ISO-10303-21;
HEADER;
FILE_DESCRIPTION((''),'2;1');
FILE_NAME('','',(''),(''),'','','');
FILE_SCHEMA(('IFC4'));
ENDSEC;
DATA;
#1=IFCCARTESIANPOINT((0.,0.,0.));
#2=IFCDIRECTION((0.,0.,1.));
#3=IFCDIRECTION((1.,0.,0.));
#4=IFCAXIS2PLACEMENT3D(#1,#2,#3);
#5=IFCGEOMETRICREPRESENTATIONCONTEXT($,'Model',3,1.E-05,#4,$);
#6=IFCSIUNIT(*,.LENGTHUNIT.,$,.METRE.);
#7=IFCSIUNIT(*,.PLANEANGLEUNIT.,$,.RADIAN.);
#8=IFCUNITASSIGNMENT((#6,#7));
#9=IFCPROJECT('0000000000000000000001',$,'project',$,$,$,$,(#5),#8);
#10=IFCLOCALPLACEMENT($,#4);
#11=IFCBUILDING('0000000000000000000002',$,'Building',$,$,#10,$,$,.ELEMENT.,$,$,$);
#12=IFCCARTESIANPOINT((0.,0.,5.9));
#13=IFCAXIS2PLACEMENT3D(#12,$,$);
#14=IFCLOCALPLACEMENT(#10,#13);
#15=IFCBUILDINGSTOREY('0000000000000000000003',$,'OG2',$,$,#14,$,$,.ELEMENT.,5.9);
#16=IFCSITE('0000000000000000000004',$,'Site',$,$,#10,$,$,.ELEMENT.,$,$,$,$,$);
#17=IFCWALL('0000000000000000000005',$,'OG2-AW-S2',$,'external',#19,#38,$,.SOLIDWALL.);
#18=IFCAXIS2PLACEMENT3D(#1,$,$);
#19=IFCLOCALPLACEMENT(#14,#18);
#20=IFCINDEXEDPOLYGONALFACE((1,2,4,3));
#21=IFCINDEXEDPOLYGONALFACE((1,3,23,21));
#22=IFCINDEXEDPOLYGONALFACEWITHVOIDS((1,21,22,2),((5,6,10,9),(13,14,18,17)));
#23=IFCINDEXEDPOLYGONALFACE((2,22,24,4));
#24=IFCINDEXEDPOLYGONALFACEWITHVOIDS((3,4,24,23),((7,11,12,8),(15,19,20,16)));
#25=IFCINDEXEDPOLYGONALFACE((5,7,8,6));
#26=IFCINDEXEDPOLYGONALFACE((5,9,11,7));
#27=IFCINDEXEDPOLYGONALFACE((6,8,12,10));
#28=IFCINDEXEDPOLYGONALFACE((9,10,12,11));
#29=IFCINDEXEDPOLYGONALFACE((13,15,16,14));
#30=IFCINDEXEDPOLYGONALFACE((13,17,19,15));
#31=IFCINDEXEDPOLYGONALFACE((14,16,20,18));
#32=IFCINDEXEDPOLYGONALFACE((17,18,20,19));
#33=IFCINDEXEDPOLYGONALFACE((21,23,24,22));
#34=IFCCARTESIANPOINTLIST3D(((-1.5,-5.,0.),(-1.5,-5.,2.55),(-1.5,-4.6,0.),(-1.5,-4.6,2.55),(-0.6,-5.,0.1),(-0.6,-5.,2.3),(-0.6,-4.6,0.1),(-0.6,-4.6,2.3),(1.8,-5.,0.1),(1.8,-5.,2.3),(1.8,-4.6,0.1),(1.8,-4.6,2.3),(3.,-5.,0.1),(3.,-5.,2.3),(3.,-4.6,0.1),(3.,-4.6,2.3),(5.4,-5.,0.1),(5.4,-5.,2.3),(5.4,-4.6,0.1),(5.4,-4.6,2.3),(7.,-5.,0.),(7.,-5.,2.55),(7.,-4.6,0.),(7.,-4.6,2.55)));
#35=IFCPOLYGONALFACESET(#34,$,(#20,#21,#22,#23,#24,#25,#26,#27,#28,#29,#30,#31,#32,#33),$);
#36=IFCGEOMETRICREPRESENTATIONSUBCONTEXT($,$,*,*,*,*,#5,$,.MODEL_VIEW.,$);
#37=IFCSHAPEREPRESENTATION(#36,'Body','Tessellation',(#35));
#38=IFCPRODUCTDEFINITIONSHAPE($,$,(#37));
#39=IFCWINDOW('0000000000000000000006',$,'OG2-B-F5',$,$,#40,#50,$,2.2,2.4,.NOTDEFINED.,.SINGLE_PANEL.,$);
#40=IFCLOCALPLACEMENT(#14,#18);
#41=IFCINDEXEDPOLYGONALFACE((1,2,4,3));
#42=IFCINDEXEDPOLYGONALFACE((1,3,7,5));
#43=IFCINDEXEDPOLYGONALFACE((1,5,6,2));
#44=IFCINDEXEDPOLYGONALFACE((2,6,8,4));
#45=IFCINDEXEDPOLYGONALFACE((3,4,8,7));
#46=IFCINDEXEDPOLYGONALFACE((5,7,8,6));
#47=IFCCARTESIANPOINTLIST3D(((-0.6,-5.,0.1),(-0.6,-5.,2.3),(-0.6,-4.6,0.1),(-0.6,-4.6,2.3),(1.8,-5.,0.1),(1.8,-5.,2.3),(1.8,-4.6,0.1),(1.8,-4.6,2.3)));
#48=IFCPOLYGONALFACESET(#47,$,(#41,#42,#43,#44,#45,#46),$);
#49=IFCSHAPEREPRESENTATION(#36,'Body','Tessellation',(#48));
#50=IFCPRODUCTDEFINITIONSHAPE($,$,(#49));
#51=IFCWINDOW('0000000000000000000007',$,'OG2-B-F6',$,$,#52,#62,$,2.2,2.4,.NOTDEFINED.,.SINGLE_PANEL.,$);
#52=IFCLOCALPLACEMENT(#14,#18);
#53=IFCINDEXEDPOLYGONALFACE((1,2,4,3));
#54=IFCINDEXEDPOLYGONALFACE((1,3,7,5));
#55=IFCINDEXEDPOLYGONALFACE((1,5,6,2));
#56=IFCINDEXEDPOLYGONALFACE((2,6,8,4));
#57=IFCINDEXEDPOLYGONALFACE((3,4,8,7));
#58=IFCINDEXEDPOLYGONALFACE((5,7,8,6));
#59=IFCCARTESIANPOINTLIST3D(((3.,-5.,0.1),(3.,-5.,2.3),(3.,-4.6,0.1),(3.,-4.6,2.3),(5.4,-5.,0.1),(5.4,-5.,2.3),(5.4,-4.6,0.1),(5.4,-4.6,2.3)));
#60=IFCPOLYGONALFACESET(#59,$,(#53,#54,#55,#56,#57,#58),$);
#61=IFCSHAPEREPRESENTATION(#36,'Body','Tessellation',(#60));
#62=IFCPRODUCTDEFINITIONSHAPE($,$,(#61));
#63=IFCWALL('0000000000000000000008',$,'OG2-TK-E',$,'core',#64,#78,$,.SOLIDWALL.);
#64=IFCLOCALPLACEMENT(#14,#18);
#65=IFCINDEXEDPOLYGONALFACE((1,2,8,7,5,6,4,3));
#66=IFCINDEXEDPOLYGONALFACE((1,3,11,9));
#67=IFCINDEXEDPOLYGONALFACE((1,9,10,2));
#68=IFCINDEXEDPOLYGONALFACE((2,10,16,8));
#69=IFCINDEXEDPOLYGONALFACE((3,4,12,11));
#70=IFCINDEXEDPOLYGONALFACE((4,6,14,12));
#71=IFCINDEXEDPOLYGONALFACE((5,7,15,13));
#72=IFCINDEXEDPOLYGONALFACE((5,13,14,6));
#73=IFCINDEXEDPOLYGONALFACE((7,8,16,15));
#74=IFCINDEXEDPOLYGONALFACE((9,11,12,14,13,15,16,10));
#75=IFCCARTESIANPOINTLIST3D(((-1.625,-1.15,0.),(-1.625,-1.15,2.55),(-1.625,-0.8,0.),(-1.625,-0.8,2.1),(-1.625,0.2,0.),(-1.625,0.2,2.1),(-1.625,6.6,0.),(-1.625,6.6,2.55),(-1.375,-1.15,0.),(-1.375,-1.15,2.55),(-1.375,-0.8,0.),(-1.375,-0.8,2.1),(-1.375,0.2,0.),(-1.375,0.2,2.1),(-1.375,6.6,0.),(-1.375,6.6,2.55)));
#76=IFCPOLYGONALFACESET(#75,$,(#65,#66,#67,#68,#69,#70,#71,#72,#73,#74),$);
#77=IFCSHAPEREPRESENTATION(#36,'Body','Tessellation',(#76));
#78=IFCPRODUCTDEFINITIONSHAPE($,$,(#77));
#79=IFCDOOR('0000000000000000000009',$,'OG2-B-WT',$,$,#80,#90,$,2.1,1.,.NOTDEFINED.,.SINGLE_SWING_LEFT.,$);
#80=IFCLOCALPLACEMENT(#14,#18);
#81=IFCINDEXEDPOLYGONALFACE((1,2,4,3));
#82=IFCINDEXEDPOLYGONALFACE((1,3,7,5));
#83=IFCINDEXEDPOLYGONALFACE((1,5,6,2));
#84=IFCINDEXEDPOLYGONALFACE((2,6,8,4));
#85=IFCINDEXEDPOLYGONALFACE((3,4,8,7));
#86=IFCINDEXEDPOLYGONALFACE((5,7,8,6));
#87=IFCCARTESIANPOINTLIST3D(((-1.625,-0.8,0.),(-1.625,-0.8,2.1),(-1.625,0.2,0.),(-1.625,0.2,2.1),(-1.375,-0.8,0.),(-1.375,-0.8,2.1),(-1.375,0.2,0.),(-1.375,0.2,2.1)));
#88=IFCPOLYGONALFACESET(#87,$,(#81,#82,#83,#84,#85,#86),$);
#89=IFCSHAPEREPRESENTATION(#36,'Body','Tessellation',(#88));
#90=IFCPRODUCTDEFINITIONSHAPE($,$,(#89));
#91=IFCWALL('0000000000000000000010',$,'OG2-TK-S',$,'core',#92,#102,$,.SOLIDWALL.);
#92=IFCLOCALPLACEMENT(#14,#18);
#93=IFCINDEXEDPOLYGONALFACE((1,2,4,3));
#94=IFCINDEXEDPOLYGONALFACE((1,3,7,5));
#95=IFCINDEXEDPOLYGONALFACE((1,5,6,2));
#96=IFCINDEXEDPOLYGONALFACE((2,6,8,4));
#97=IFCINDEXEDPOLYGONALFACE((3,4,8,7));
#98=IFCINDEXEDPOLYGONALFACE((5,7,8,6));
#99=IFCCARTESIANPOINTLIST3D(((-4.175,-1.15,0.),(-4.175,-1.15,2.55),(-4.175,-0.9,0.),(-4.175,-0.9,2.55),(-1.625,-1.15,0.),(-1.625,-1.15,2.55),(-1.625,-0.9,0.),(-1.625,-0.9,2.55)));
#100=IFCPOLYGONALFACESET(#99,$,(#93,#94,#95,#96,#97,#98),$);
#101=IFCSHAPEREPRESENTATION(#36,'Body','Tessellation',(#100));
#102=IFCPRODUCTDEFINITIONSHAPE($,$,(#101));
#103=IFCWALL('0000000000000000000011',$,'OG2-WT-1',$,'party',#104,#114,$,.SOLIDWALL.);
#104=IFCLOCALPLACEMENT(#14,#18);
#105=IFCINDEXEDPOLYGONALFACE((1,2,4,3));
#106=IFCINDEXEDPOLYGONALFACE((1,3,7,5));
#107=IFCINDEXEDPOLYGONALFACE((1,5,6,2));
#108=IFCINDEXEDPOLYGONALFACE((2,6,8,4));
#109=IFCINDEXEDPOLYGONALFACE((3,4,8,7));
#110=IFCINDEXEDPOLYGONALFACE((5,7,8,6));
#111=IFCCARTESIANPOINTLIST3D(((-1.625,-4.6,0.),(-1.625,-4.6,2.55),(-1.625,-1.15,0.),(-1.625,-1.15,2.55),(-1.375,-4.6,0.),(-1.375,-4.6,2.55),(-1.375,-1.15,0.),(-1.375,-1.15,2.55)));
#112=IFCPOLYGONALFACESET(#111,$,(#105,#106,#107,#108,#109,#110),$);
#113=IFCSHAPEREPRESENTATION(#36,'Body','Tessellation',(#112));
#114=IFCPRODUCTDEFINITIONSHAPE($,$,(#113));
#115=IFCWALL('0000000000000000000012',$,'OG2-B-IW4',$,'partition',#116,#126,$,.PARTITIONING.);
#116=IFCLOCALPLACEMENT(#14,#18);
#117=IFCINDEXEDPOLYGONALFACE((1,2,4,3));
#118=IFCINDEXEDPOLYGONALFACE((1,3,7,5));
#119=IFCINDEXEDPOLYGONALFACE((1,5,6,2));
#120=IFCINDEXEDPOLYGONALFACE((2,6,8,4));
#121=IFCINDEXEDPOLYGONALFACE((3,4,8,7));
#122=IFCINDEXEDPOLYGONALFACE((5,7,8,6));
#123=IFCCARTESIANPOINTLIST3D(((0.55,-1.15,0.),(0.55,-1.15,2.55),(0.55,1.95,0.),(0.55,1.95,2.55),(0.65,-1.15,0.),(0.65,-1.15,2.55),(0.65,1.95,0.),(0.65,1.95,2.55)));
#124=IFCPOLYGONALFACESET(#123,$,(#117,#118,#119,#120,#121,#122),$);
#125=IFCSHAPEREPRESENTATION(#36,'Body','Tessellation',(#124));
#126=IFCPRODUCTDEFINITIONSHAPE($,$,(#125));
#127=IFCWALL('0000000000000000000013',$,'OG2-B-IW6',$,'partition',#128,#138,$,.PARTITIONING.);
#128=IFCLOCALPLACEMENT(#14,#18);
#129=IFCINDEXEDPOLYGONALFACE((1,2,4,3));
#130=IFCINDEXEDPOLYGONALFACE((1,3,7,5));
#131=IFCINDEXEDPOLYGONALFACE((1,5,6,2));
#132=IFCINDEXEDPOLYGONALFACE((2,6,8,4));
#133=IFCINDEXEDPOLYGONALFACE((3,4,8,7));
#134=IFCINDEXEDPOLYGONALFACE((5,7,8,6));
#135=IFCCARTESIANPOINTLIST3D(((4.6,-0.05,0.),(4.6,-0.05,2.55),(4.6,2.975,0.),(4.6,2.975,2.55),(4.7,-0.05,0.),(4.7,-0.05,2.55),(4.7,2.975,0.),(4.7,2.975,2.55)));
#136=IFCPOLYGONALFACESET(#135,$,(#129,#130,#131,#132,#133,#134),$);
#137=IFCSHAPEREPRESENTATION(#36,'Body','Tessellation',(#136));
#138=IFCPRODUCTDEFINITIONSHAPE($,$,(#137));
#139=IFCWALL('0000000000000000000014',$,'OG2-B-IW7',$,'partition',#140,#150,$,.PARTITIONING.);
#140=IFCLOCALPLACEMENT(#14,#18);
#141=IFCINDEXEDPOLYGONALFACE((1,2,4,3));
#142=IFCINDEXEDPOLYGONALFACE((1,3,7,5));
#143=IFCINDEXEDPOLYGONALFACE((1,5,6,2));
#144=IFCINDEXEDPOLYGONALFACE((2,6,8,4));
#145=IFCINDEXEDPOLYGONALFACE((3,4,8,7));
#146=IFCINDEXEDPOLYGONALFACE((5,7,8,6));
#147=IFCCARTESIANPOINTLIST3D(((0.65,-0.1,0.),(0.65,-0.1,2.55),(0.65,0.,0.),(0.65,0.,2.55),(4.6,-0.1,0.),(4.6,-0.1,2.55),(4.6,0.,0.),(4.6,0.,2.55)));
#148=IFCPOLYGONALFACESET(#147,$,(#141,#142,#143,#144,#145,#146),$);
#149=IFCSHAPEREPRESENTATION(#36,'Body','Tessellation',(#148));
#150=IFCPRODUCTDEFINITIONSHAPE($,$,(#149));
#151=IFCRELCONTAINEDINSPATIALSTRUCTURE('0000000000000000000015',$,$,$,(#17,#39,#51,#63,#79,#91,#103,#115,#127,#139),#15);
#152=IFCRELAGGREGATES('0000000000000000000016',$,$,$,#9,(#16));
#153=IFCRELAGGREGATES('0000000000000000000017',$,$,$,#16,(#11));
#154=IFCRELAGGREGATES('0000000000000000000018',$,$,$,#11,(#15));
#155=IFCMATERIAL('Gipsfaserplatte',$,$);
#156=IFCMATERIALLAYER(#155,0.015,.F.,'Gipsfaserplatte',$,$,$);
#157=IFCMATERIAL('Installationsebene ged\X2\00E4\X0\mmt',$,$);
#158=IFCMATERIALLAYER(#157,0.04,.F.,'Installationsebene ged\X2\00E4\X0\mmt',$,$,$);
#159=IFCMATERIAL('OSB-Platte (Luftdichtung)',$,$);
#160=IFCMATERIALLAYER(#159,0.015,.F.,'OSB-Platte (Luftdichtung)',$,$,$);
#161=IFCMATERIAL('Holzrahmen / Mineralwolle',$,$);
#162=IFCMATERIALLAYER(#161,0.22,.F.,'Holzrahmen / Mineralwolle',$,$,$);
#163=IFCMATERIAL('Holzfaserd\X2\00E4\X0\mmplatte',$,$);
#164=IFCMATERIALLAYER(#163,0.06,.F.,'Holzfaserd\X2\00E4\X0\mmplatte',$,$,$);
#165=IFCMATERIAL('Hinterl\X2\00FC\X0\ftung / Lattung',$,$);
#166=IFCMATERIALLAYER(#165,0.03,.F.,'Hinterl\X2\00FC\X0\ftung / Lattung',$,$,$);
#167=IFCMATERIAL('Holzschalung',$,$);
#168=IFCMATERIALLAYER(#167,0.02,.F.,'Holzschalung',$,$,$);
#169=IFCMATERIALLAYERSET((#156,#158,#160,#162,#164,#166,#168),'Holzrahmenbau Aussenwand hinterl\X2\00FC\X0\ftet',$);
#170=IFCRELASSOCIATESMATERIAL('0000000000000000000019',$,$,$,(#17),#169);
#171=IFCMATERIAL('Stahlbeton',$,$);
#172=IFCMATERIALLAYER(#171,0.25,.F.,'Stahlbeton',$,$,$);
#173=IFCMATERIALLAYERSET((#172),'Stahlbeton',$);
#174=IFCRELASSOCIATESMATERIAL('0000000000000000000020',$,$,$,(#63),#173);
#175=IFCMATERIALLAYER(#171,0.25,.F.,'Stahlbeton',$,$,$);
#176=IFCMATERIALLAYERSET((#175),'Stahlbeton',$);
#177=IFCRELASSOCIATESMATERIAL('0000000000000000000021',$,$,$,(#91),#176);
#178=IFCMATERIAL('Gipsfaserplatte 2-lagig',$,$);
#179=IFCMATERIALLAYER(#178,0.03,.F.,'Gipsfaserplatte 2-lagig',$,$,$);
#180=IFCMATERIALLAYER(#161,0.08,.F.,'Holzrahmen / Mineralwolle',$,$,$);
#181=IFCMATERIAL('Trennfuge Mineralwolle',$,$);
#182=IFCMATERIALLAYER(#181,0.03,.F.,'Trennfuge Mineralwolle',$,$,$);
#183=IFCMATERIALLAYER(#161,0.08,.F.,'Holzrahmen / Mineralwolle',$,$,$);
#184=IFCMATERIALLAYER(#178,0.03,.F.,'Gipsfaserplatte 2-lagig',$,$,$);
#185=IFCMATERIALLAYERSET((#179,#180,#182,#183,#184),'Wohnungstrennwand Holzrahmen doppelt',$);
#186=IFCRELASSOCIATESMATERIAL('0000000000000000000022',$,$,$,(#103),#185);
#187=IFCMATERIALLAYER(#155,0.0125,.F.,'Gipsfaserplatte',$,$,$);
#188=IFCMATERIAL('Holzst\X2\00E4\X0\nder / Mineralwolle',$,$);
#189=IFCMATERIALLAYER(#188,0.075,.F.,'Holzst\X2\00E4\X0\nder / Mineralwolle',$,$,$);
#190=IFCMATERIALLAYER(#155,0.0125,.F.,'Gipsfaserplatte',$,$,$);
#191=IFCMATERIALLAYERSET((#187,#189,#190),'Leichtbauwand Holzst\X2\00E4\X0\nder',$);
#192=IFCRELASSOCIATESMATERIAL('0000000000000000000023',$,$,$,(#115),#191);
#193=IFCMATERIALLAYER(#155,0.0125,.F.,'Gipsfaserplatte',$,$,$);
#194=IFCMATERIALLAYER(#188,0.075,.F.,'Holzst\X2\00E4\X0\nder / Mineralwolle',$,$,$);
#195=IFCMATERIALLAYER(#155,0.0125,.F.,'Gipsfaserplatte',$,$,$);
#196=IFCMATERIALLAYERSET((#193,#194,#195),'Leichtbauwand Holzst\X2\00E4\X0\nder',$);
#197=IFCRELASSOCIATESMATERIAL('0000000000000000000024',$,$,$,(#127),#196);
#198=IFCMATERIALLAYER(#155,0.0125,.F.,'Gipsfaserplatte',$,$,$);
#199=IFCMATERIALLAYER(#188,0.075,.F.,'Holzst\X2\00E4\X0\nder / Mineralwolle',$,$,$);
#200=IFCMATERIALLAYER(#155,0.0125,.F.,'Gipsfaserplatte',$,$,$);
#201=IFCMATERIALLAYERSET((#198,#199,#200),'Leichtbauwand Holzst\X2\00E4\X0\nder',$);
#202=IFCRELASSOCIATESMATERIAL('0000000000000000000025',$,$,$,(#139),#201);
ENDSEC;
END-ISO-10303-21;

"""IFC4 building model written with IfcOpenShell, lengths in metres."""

from ifc_helpers import new_model, si_unit, frame, frame_2d, origin, origin_with_axes, place, context, subcontext, project, spatial, rectangle, extrude, material, layer, layer_set, element, fill, save


model = new_model("IFC4")

# Units and contexts
model_context = context("Model", 3, precision=1e-05, world=origin_with_axes())
sub_context = subcontext(model_context, None, None, "MODEL_VIEW")
ifc_project = project(units=[si_unit("LENGTHUNIT", "METRE"), si_unit("PLANEANGLEUNIT", "RADIAN")], contexts=[model_context])

# Site, building, storey
placement = place(None, origin_with_axes())
site = spatial("IfcSite", under=ifc_project, at=placement, Name="Site", CompositionType="ELEMENT")
building = spatial("IfcBuilding", under=site, at=placement, Name="Building", CompositionType="ELEMENT")
storey_placement = place(placement, frame((0.0, 0.0, 5.9)))
storey = spatial("IfcBuildingStorey", under=building, at=storey_placement, Name="OG2", CompositionType="ELEMENT", Elevation=5.9)

# Wall, openings, windows
ifc_material_1 = material(Name="Gipsfaserplatte")
ifc_layer_1 = layer(ifc_material_1, 0.015, ventilated=False, Name="Gipsfaserplatte")
ifc_material_2 = material(Name="Installationsebene gedämmt")
ifc_layer_2 = layer(ifc_material_2, 0.04, ventilated=False, Name="Installationsebene gedämmt")
ifc_material_3 = material(Name="OSB-Platte (Luftdichtung)")
ifc_layer_3 = layer(ifc_material_3, 0.015, ventilated=False, Name="OSB-Platte (Luftdichtung)")
ifc_material_4 = material(Name="Holzrahmen / Mineralwolle")
ifc_layer_4 = layer(ifc_material_4, 0.22, ventilated=False, Name="Holzrahmen / Mineralwolle")
ifc_material_5 = material(Name="Holzfaserdämmplatte")
ifc_layer_5 = layer(ifc_material_5, 0.06, ventilated=False, Name="Holzfaserdämmplatte")
ifc_material_6 = material(Name="Hinterlüftung / Lattung")
ifc_layer_6 = layer(ifc_material_6, 0.03, ventilated=False, Name="Hinterlüftung / Lattung")
ifc_material_7 = material(Name="Holzschalung")
ifc_layer_7 = layer(ifc_material_7, 0.02, ventilated=False, Name="Holzschalung")
ifc_layer_set_1 = layer_set([ifc_layer_1, ifc_layer_2, ifc_layer_3, ifc_layer_4, ifc_layer_5, ifc_layer_6, ifc_layer_7], Name="Holzrahmenbau Aussenwand hinterlüftet")
wall_1_placement = place(storey_placement, frame((7.0, -4.8, 0.0), z_axis=(0.0, 0.0, 1.0), x_axis=(-1.0, 0.0, 0.0)))
wall_1 = element("IfcWall", 1, at=wall_1_placement, inside=storey, material=ifc_layer_set_1, Name="OG2-AW-S2", ObjectType="external", PredefinedType="SOLIDWALL", context=sub_context, shape_type="SweptSolid", body=[
    extrude(rectangle(XDim=8.5, YDim=0.4, at=frame_2d((4.25, 0.0))), origin(), (0.0, 0.0, 1.0), 2.55),
])
opening_1_placement = place(wall_1_placement, frame((6.4, 0.25, 0.1), z_axis=(0.0, -1.0, 0.0), x_axis=(1.0, 0.0, 0.0)))
opening_1 = element("IfcOpeningElement", 2, at=opening_1_placement, cuts=wall_1, PredefinedType="OPENING", context=sub_context, shape_type="SweptSolid", body=[
    extrude(rectangle(XDim=2.4, YDim=2.2, at=frame_2d((0.0, 1.1))), origin(), (0.0, 0.0, 1.0), 0.5),
])
opening_2_placement = place(wall_1_placement, frame((2.8, 0.25, 0.1), z_axis=(0.0, -1.0, 0.0), x_axis=(1.0, 0.0, 0.0)))
opening_2 = element("IfcOpeningElement", 3, at=opening_2_placement, cuts=wall_1, PredefinedType="OPENING", context=sub_context, shape_type="SweptSolid", body=[
    extrude(rectangle(XDim=2.4, YDim=2.2, at=frame_2d((0.0, 1.1))), origin(), (0.0, 0.0, 1.0), 0.5),
])
window_1_placement = place(wall_1_placement, frame((6.4, 0.2, 0.1), z_axis=(0.0, -1.0, 0.0), x_axis=(1.0, 0.0, 0.0)))
window_1 = element("IfcWindow", 4, at=window_1_placement, inside=storey, Name="OG2-B-F5", OverallHeight=2.2, OverallWidth=2.4, PartitioningType="SINGLE_PANEL", PredefinedType="NOTDEFINED", context=sub_context, shape_type="SweptSolid", body=[
    extrude(rectangle(XDim=2.4, YDim=2.2, at=frame_2d((0.0, 1.1))), origin(), (0.0, 0.0, 1.0), 0.4),
])
fill(opening_1, window_1)
window_2_placement = place(wall_1_placement, frame((2.8, 0.2, 0.1), z_axis=(0.0, -1.0, 0.0), x_axis=(1.0, 0.0, 0.0)))
window_2 = element("IfcWindow", 5, at=window_2_placement, inside=storey, Name="OG2-B-F6", OverallHeight=2.2, OverallWidth=2.4, PartitioningType="SINGLE_PANEL", PredefinedType="NOTDEFINED", context=sub_context, shape_type="SweptSolid", body=[
    extrude(rectangle(XDim=2.4, YDim=2.2, at=frame_2d((0.0, 1.1))), origin(), (0.0, 0.0, 1.0), 0.4),
])
fill(opening_2, window_2)

# Wall, opening, door
ifc_material_8 = material(Name="Stahlbeton")
ifc_layer_8 = layer(ifc_material_8, 0.25, ventilated=False, Name="Stahlbeton")
ifc_layer_set_2 = layer_set([ifc_layer_8], Name="Stahlbeton")
wall_2_placement = place(storey_placement, frame((-1.5, -1.15, 0.0), z_axis=(0.0, 0.0, 1.0), x_axis=(0.0, 1.0, 0.0)))
wall_2 = element("IfcWall", 6, at=wall_2_placement, inside=storey, material=ifc_layer_set_2, Name="OG2-TK-E", ObjectType="core", PredefinedType="SOLIDWALL", context=sub_context, shape_type="SweptSolid", body=[
    extrude(rectangle(XDim=7.75, YDim=0.25, at=frame_2d((3.875, 0.0))), origin(), (0.0, 0.0, 1.0), 2.55),
])
opening_3_placement = place(wall_2_placement, frame((0.85, 0.175, 0.0), z_axis=(0.0, -1.0, 0.0), x_axis=(1.0, 0.0, 0.0)))
opening_3 = element("IfcOpeningElement", 7, at=opening_3_placement, cuts=wall_2, PredefinedType="OPENING", context=sub_context, shape_type="SweptSolid", body=[
    extrude(rectangle(XDim=1.0, YDim=2.1, at=frame_2d((0.0, 1.05))), origin(), (0.0, 0.0, 1.0), 0.35),
])
door_1_placement = place(wall_2_placement, frame((0.85, 0.125, 0.0), z_axis=(0.0, -1.0, 0.0), x_axis=(1.0, 0.0, 0.0)))
door_1 = element("IfcDoor", 8, at=door_1_placement, inside=storey, Name="OG2-B-WT", OperationType="SINGLE_SWING_LEFT", OverallHeight=2.1, OverallWidth=1.0, PredefinedType="NOTDEFINED", context=sub_context, shape_type="SweptSolid", body=[
    extrude(rectangle(XDim=1.0, YDim=2.1, at=frame_2d((0.0, 1.05))), origin(), (0.0, 0.0, 1.0), 0.25),
])
fill(opening_3, door_1)

# Walls
ifc_layer_9 = layer(ifc_material_8, 0.25, ventilated=False, Name="Stahlbeton")
ifc_layer_set_3 = layer_set([ifc_layer_9], Name="Stahlbeton")
wall_3_placement = place(storey_placement, frame((-4.175, -1.025, 0.0), z_axis=(0.0, 0.0, 1.0), x_axis=(1.0, 0.0, 0.0)))
element("IfcWall", 9, at=wall_3_placement, inside=storey, material=ifc_layer_set_3, Name="OG2-TK-S", ObjectType="core", PredefinedType="SOLIDWALL", context=sub_context, shape_type="SweptSolid", body=[
    extrude(rectangle(XDim=2.55, YDim=0.25, at=frame_2d((1.275, 0.0))), origin(), (0.0, 0.0, 1.0), 2.55),
])
ifc_material_9 = material(Name="Gipsfaserplatte 2-lagig")
ifc_layer_10 = layer(ifc_material_9, 0.03, ventilated=False, Name="Gipsfaserplatte 2-lagig")
ifc_layer_11 = layer(ifc_material_4, 0.08, ventilated=False, Name="Holzrahmen / Mineralwolle")
ifc_material_10 = material(Name="Trennfuge Mineralwolle")
ifc_layer_12 = layer(ifc_material_10, 0.03, ventilated=False, Name="Trennfuge Mineralwolle")
ifc_layer_13 = layer(ifc_material_4, 0.08, ventilated=False, Name="Holzrahmen / Mineralwolle")
ifc_layer_14 = layer(ifc_material_9, 0.03, ventilated=False, Name="Gipsfaserplatte 2-lagig")
ifc_layer_set_4 = layer_set([ifc_layer_10, ifc_layer_11, ifc_layer_12, ifc_layer_13, ifc_layer_14], Name="Wohnungstrennwand Holzrahmen doppelt")
wall_4_placement = place(storey_placement, frame((-1.5, -1.15, 0.0), z_axis=(0.0, 0.0, 1.0), x_axis=(0.0, -1.0, 0.0)))
element("IfcWall", 10, at=wall_4_placement, inside=storey, material=ifc_layer_set_4, Name="OG2-WT-1", ObjectType="party", PredefinedType="SOLIDWALL", context=sub_context, shape_type="SweptSolid", body=[
    extrude(rectangle(XDim=3.45, YDim=0.25, at=frame_2d((1.725, 0.0))), origin(), (0.0, 0.0, 1.0), 2.55),
])
ifc_layer_15 = layer(ifc_material_1, 0.0125, ventilated=False, Name="Gipsfaserplatte")
ifc_material_11 = material(Name="Holzständer / Mineralwolle")
ifc_layer_16 = layer(ifc_material_11, 0.075, ventilated=False, Name="Holzständer / Mineralwolle")
ifc_layer_17 = layer(ifc_material_1, 0.0125, ventilated=False, Name="Gipsfaserplatte")
ifc_layer_set_5 = layer_set([ifc_layer_15, ifc_layer_16, ifc_layer_17], Name="Leichtbauwand Holzständer")
wall_5_placement = place(storey_placement, frame((0.6, -1.15, 0.0), z_axis=(0.0, 0.0, 1.0), x_axis=(0.0, 1.0, 0.0)))
element("IfcWall", 11, at=wall_5_placement, inside=storey, material=ifc_layer_set_5, Name="OG2-B-IW4", ObjectType="partition", PredefinedType="PARTITIONING", context=sub_context, shape_type="SweptSolid", body=[
    extrude(rectangle(XDim=3.1, YDim=0.1, at=frame_2d((1.55, 0.0))), origin(), (0.0, 0.0, 1.0), 2.55),
])
ifc_layer_18 = layer(ifc_material_1, 0.0125, ventilated=False, Name="Gipsfaserplatte")
ifc_layer_19 = layer(ifc_material_11, 0.075, ventilated=False, Name="Holzständer / Mineralwolle")
ifc_layer_20 = layer(ifc_material_1, 0.0125, ventilated=False, Name="Gipsfaserplatte")
ifc_layer_set_6 = layer_set([ifc_layer_18, ifc_layer_19, ifc_layer_20], Name="Leichtbauwand Holzständer")
wall_6_placement = place(storey_placement, frame((4.65, -0.05, 0.0), z_axis=(0.0, 0.0, 1.0), x_axis=(0.0, 1.0, 0.0)))
element("IfcWall", 12, at=wall_6_placement, inside=storey, material=ifc_layer_set_6, Name="OG2-B-IW6", ObjectType="partition", PredefinedType="PARTITIONING", context=sub_context, shape_type="SweptSolid", body=[
    extrude(rectangle(XDim=3.025, YDim=0.1, at=frame_2d((1.5125, 0.0))), origin(), (0.0, 0.0, 1.0), 2.55),
])
ifc_layer_21 = layer(ifc_material_1, 0.0125, ventilated=False, Name="Gipsfaserplatte")
ifc_layer_22 = layer(ifc_material_11, 0.075, ventilated=False, Name="Holzständer / Mineralwolle")
ifc_layer_23 = layer(ifc_material_1, 0.0125, ventilated=False, Name="Gipsfaserplatte")
ifc_layer_set_7 = layer_set([ifc_layer_21, ifc_layer_22, ifc_layer_23], Name="Leichtbauwand Holzständer")
wall_7_placement = place(storey_placement, frame((0.65, -0.05, 0.0), z_axis=(0.0, 0.0, 1.0), x_axis=(1.0, 0.0, 0.0)))
element("IfcWall", 13, at=wall_7_placement, inside=storey, material=ifc_layer_set_7, Name="OG2-B-IW7", ObjectType="partition", PredefinedType="PARTITIONING", context=sub_context, shape_type="SweptSolid", body=[
    extrude(rectangle(XDim=3.95, YDim=0.1, at=frame_2d((1.975, 0.0))), origin(), (0.0, 0.0, 1.0), 2.55),
])

save(model, "model.ifc")
